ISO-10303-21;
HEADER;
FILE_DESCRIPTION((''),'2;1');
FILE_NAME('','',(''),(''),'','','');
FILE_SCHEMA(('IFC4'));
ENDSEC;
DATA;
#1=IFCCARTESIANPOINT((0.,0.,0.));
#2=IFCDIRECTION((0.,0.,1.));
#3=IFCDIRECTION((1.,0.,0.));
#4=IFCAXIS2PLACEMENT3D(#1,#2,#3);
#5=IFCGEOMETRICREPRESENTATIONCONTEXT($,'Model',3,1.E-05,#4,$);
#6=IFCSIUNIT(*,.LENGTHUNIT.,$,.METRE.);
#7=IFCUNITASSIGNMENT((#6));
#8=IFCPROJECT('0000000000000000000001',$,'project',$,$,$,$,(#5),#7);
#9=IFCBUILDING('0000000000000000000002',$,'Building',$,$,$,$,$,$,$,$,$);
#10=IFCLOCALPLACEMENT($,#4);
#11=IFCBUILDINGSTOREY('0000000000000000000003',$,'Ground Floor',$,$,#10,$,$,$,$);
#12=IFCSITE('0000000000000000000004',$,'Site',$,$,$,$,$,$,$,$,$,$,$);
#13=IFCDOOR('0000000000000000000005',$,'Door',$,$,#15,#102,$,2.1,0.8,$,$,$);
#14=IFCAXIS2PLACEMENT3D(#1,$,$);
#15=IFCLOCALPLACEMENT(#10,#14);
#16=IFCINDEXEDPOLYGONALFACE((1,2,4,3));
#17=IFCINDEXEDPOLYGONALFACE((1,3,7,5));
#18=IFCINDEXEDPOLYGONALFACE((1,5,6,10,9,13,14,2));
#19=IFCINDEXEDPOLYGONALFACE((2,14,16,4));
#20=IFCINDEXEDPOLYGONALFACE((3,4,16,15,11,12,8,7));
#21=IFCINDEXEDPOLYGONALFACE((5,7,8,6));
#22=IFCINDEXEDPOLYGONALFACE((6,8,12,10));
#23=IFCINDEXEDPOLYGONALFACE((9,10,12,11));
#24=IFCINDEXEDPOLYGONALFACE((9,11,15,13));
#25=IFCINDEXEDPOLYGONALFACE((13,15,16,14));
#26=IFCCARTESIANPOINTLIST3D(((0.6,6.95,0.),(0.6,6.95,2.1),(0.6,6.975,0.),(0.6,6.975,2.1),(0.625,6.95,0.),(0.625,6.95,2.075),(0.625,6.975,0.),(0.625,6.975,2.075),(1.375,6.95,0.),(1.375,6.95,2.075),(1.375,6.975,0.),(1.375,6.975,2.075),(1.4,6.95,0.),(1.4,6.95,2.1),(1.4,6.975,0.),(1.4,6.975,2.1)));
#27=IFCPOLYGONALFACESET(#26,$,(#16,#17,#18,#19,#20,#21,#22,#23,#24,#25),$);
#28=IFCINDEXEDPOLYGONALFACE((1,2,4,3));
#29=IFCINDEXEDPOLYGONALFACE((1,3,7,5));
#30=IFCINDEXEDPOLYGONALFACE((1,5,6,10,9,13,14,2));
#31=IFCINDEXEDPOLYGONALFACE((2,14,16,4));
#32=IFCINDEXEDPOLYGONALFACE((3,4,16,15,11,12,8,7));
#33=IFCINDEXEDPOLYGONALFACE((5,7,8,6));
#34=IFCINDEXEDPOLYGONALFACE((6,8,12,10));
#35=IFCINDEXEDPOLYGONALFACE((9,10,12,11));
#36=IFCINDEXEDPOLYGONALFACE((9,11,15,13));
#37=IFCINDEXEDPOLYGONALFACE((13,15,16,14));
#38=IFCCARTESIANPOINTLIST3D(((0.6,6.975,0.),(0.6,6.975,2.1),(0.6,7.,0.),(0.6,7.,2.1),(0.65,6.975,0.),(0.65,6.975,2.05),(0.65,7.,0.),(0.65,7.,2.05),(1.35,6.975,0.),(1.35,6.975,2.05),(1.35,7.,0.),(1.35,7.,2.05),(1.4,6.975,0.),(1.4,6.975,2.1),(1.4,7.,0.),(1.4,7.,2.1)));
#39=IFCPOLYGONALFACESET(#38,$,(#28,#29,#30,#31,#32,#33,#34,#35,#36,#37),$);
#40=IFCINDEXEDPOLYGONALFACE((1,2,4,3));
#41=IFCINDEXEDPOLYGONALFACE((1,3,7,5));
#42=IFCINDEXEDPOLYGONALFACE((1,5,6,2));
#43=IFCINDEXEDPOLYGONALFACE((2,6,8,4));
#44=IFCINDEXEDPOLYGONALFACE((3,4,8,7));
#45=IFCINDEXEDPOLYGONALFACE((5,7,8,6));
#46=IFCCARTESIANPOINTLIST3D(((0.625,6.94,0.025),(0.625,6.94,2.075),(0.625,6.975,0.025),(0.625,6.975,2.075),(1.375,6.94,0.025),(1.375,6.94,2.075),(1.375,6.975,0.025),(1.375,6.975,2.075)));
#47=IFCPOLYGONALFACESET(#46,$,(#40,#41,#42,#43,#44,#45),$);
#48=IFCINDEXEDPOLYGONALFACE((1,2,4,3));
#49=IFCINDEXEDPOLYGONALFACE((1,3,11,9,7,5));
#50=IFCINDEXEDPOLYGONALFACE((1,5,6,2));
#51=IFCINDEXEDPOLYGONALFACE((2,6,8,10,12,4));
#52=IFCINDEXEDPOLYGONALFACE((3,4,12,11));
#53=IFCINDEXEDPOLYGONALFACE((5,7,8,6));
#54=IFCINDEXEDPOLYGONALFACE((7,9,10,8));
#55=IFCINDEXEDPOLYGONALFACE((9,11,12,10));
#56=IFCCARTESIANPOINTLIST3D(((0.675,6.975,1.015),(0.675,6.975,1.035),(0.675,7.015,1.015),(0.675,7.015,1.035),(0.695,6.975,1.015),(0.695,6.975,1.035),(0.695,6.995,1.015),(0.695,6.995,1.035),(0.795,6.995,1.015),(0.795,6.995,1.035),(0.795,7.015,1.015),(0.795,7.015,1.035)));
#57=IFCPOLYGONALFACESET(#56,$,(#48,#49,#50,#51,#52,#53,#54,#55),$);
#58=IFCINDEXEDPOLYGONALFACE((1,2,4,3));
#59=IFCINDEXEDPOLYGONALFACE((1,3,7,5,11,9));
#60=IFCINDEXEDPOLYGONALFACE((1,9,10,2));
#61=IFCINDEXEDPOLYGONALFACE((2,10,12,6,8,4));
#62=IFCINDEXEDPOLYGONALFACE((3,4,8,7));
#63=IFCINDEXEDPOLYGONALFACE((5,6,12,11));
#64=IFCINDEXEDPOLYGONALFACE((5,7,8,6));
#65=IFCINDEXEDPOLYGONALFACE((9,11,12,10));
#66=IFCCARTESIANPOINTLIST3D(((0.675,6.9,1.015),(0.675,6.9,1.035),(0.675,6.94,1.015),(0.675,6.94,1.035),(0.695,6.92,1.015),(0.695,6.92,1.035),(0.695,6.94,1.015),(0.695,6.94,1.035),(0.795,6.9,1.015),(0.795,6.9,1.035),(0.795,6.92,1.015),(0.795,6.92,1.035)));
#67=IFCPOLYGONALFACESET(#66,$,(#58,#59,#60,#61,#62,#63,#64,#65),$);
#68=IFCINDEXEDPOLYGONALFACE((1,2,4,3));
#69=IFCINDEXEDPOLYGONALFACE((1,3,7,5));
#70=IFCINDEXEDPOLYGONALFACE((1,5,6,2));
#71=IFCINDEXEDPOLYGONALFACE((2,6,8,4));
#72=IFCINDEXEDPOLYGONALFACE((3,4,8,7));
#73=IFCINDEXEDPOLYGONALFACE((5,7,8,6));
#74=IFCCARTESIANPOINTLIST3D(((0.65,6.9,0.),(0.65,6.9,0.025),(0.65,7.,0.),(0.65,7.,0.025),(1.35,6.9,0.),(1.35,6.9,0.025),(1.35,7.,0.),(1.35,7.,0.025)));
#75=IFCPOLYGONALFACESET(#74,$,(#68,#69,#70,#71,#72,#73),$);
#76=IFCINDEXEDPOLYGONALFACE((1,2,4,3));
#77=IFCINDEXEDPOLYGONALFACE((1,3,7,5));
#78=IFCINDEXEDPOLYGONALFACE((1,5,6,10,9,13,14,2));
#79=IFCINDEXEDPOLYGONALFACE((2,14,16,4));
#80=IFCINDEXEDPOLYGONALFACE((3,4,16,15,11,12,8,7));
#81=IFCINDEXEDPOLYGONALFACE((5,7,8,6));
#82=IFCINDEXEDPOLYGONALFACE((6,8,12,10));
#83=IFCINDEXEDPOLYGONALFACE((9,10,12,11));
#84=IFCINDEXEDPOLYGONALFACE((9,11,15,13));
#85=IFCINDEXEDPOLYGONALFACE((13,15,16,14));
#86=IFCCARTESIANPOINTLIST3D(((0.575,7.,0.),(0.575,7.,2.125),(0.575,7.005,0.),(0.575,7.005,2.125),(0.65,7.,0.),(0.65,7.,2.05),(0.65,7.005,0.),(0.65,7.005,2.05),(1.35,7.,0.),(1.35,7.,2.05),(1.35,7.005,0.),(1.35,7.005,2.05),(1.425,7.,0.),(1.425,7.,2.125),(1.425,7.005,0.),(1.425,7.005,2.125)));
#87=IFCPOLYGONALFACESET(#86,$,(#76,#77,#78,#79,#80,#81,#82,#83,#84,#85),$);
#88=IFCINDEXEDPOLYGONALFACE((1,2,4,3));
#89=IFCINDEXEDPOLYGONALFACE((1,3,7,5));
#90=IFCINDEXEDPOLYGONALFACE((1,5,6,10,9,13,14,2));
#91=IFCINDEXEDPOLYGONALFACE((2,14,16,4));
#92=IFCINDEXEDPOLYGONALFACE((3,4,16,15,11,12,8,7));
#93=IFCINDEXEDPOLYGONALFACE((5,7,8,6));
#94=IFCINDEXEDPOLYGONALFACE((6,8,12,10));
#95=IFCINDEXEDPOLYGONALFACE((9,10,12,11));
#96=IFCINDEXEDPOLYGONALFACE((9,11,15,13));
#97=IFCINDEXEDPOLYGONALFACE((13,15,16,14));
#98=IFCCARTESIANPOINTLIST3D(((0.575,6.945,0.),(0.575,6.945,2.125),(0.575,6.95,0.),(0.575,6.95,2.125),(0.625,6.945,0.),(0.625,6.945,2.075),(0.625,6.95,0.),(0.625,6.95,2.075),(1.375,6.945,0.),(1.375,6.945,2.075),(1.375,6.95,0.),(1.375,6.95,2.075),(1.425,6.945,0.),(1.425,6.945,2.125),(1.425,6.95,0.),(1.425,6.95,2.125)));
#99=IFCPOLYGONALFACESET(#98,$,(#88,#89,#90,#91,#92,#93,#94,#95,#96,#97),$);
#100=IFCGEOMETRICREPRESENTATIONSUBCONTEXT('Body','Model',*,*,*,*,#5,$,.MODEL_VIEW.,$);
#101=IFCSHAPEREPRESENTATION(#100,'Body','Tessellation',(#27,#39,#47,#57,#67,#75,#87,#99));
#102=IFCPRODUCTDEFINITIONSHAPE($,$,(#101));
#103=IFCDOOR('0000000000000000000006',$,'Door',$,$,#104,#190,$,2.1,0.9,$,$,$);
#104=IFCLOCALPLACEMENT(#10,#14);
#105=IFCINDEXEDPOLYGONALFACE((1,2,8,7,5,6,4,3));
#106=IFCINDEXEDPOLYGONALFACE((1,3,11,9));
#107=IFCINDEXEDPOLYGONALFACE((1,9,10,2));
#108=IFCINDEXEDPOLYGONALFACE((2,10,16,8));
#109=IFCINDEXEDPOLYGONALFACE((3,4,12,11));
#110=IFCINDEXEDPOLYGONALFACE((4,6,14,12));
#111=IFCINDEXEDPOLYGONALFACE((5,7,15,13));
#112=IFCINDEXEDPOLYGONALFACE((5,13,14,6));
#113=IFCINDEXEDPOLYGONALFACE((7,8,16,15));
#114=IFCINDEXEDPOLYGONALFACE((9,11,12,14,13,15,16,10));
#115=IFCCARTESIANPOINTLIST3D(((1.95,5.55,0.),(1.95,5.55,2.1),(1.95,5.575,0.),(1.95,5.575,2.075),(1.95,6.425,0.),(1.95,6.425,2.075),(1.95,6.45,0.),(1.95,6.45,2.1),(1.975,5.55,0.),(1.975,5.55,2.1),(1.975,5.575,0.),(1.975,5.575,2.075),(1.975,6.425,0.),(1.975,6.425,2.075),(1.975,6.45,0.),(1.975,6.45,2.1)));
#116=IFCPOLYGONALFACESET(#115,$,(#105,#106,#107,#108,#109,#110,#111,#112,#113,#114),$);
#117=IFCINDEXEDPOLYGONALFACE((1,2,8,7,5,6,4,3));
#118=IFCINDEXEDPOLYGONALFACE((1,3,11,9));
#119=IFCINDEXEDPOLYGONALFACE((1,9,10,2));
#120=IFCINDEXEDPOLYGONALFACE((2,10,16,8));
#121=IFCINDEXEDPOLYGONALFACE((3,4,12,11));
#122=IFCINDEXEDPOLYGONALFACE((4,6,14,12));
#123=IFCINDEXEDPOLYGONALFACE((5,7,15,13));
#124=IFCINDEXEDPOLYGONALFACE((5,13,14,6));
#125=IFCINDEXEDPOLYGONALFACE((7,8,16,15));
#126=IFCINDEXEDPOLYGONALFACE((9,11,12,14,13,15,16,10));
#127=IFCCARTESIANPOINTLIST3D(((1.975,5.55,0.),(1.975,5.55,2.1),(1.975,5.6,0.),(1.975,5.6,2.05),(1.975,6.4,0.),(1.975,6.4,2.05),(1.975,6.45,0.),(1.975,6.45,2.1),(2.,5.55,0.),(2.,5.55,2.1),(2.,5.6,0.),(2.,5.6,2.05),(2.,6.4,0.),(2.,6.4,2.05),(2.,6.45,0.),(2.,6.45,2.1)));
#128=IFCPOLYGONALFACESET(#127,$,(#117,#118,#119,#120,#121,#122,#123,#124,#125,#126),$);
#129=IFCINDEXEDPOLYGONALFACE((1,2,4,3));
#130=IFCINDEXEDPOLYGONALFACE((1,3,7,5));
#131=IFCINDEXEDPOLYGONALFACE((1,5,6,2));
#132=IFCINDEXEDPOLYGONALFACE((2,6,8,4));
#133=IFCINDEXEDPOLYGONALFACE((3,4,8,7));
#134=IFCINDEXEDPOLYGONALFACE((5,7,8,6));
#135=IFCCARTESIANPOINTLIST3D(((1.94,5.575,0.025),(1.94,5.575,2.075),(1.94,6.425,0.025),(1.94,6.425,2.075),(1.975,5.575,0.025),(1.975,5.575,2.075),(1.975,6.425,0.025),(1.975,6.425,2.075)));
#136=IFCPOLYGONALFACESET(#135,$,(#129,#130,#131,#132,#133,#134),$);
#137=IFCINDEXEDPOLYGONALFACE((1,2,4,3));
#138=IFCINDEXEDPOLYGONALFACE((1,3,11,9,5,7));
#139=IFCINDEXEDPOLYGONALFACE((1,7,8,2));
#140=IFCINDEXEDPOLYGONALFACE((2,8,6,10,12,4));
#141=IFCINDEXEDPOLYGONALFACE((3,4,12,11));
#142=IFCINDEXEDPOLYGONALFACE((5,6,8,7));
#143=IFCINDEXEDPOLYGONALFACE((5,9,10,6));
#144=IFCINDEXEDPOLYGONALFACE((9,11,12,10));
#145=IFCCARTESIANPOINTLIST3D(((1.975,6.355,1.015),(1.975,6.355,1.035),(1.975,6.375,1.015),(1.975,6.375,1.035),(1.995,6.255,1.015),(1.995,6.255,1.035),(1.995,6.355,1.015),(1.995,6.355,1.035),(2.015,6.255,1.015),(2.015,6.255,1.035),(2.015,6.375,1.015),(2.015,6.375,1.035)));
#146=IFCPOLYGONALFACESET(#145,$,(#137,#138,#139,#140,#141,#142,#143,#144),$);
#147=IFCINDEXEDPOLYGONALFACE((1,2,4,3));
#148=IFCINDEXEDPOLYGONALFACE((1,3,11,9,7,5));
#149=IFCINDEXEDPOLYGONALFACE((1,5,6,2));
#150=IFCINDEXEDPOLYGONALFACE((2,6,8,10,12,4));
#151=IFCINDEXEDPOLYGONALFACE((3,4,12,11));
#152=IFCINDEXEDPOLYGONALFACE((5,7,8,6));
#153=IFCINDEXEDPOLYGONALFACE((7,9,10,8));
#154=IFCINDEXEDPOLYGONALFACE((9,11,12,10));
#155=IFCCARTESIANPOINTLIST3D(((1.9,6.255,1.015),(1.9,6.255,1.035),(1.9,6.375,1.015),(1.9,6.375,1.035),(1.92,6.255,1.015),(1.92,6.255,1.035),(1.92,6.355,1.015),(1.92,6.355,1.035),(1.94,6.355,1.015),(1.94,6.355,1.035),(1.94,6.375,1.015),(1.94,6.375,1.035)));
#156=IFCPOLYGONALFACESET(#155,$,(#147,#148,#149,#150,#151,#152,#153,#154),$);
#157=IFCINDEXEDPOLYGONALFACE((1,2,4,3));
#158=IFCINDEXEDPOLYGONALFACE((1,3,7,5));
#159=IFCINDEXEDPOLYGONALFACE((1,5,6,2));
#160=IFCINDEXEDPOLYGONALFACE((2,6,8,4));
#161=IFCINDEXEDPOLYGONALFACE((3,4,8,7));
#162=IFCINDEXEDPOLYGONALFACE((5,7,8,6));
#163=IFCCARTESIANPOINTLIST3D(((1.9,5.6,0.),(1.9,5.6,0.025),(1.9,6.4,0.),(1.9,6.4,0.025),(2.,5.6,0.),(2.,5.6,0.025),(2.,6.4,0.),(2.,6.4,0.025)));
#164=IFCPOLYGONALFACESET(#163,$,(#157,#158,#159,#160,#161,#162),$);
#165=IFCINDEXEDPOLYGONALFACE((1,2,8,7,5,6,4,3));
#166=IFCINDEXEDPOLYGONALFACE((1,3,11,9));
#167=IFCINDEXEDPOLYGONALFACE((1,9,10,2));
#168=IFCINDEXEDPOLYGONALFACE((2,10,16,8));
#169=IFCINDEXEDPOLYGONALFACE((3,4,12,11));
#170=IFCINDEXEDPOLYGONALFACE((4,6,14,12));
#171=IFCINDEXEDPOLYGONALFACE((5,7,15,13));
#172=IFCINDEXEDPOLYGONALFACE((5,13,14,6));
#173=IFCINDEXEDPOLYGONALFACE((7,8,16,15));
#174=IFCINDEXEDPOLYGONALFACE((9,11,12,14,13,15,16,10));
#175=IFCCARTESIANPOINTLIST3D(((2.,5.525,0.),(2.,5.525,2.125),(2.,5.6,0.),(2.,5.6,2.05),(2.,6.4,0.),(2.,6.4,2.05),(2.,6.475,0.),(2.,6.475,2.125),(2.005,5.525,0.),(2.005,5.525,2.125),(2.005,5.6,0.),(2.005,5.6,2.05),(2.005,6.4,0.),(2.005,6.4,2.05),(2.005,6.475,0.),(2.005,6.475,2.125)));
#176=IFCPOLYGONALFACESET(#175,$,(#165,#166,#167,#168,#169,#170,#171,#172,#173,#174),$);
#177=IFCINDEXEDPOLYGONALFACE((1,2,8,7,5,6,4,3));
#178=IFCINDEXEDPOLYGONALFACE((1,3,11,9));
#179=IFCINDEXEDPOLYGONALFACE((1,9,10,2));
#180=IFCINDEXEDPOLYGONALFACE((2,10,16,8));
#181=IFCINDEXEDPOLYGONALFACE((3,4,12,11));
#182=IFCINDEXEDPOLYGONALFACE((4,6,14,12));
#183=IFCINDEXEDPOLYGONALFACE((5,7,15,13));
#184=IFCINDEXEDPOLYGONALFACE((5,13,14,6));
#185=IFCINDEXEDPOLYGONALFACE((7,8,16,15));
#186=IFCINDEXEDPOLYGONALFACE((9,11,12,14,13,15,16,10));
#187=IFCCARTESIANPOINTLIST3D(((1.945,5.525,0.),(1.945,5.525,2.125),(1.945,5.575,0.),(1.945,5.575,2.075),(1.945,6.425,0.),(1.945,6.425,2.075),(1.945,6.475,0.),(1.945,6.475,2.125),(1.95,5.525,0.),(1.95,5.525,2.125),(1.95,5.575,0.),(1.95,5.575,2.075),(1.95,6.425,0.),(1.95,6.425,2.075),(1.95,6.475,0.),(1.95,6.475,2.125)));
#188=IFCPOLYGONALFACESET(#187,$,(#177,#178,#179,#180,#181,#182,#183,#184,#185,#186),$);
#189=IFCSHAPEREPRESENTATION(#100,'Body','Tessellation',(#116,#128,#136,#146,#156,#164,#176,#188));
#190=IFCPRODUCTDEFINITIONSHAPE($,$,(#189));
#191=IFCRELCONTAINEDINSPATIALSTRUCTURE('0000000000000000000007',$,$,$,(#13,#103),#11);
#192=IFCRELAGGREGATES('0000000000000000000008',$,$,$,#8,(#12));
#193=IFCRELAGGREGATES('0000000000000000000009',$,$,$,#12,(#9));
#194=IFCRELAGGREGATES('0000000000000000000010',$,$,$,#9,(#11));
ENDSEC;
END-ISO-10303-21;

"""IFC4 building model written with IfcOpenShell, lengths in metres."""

from ifc_helpers import new_model, si_unit, frame, origin_with_axes, place, context, subcontext, project, spatial, line, indexed_curve, outline, extrude, element, save


model = new_model("IFC4")

# Units and contexts
model_context = context("Model", 3, precision=1e-05, world=origin_with_axes())
body_context = subcontext(model_context, "Body", "Model", "MODEL_VIEW")
ifc_project = project(units=[si_unit("LENGTHUNIT", "METRE")], contexts=[model_context])

# Site, building, storey
site = spatial("IfcSite", under=ifc_project, Name="Site")
building = spatial("IfcBuilding", under=site, Name="Building")
storey_placement = place(None, origin_with_axes())
storey = spatial("IfcBuildingStorey", under=building, at=storey_placement, Name="Ground Floor")

# Doors
door_1_placement = place(storey_placement, frame((1.4, 7.0, 0.0), z_axis=(0.0, 0.0, 1.0), x_axis=(-1.0, 0.0, 0.0)))
element("IfcDoor", 1, at=door_1_placement, inside=storey, Name="Door", OverallHeight=2.1, OverallWidth=0.8, context=body_context, shape_type="SweptSolid", body=[
    extrude(outline(indexed_curve([(0.0, 0.0), (0.0, 2.1), (0.8, 2.1), (0.8, 0.0), (0.775, 0.0), (0.775, 2.075), (0.025, 2.075), (0.025, 0.0)], segments=[line(1, 2, 3, 4, 5, 6, 7, 8, 1)])), frame((0.0, 0.025, 0.0), z_axis=(0.0, -1.0, 0.0), x_axis=(1.0, 0.0, 0.0)), (0.0, 0.0, -1.0), 0.025),
    extrude(outline(indexed_curve([(0.0, 0.0), (0.0, 2.1), (0.8, 2.1), (0.8, 0.0), (0.75, 0.0), (0.75, 2.05), (0.05, 2.05), (0.05, 0.0)], segments=[line(1, 2, 3, 4, 5, 6, 7, 8, 1)])), frame((0.0, 0.0, 0.0), z_axis=(0.0, -1.0, 0.0), x_axis=(1.0, 0.0, 0.0)), (0.0, 0.0, -1.0), 0.025),
    extrude(outline(indexed_curve([(0.0, 0.0), (0.75, 0.0), (0.75, 0.035), (0.0, 0.035)], segments=[line(1, 2, 3, 4, 1)])), frame((0.025, 0.025, 0.025), z_axis=(0.0, 0.0, 1.0), x_axis=(1.0, 0.0, 0.0)), (0.0, 0.0, 1.0), 2.05),
    extrude(outline(indexed_curve([(0.0, 0.0), (0.0, -0.04), (-0.12, -0.04), (-0.12, -0.02), (-0.02, -0.02), (-0.02, 0.0)], segments=[line(1, 2, 3, 4, 5, 6, 1)])), frame((0.725, 0.025, 1.015), z_axis=(0.0, 0.0, 1.0), x_axis=(1.0, 0.0, 0.0)), (0.0, 0.0, 1.0), 0.02),
    extrude(outline(indexed_curve([(0.0, 0.0), (0.0, 0.04), (-0.12, 0.04), (-0.12, 0.02), (-0.02, 0.02), (-0.02, 0.0)], segments=[line(1, 2, 3, 4, 5, 6, 1)])), frame((0.725, 0.06, 1.015), z_axis=(0.0, 0.0, 1.0), x_axis=(1.0, 0.0, 0.0)), (0.0, 0.0, 1.0), 0.02),
    extrude(outline(indexed_curve([(0.0, 0.0), (0.7, 0.0), (0.7, 0.1), (0.0, 0.1)], segments=[line(1, 2, 3, 4, 1)])), frame((0.05, 0.0, 0.0), z_axis=(0.0, 0.0, 1.0), x_axis=(1.0, 0.0, 0.0)), (0.0, 0.0, 1.0), 0.025),
    extrude(outline(indexed_curve([(0.0, 0.0), (0.0, 2.125), (0.85, 2.125), (0.85, 0.0), (0.775, 0.0), (0.775, 2.05), (0.075, 2.05), (0.075, 0.0)], segments=[line(1, 2, 3, 4, 5, 6, 7, 8, 1)])), frame((-0.025, -0.005, 0.0), z_axis=(0.0, -1.0, 0.0), x_axis=(1.0, 0.0, 0.0)), (0.0, 0.0, -1.0), 0.005),
    extrude(outline(indexed_curve([(0.0, 0.0), (0.0, 2.125), (0.85, 2.125), (0.85, 0.0), (0.8, 0.0), (0.8, 2.075), (0.05, 2.075), (0.05, 0.0)], segments=[line(1, 2, 3, 4, 5, 6, 7, 8, 1)])), frame((-0.025, 0.05, 0.0), z_axis=(0.0, -1.0, 0.0), x_axis=(1.0, 0.0, 0.0)), (0.0, 0.0, -1.0), 0.005),
])
door_2_placement = place(storey_placement, frame((2.0, 5.55, 0.0), z_axis=(0.0, 0.0, 1.0), x_axis=(0.0, 1.0, 0.0)))
element("IfcDoor", 2, at=door_2_placement, inside=storey, Name="Door", OverallHeight=2.1, OverallWidth=0.9, context=body_context, shape_type="SweptSolid", body=[
    extrude(outline(indexed_curve([(0.0, 0.0), (0.0, 2.1), (0.9, 2.1), (0.9, 0.0), (0.875, 0.0), (0.875, 2.075), (0.025, 2.075), (0.025, 0.0)], segments=[line(1, 2, 3, 4, 5, 6, 7, 8, 1)])), frame((0.0, 0.025, 0.0), z_axis=(0.0, -1.0, 0.0), x_axis=(1.0, 0.0, 0.0)), (0.0, 0.0, -1.0), 0.025),
    extrude(outline(indexed_curve([(0.0, 0.0), (0.0, 2.1), (0.9, 2.1), (0.9, 0.0), (0.85, 0.0), (0.85, 2.05), (0.05, 2.05), (0.05, 0.0)], segments=[line(1, 2, 3, 4, 5, 6, 7, 8, 1)])), frame((0.0, 0.0, 0.0), z_axis=(0.0, -1.0, 0.0), x_axis=(1.0, 0.0, 0.0)), (0.0, 0.0, -1.0), 0.025),
    extrude(outline(indexed_curve([(0.0, 0.0), (0.85, 0.0), (0.85, 0.035), (0.0, 0.035)], segments=[line(1, 2, 3, 4, 1)])), frame((0.025, 0.025, 0.025), z_axis=(0.0, 0.0, 1.0), x_axis=(1.0, 0.0, 0.0)), (0.0, 0.0, 1.0), 2.05),
    extrude(outline(indexed_curve([(0.0, 0.0), (0.0, -0.04), (-0.12, -0.04), (-0.12, -0.02), (-0.02, -0.02), (-0.02, 0.0)], segments=[line(1, 2, 3, 4, 5, 6, 1)])), frame((0.825, 0.025, 1.015), z_axis=(0.0, 0.0, 1.0), x_axis=(1.0, 0.0, 0.0)), (0.0, 0.0, 1.0), 0.02),
    extrude(outline(indexed_curve([(0.0, 0.0), (0.0, 0.04), (-0.12, 0.04), (-0.12, 0.02), (-0.02, 0.02), (-0.02, 0.0)], segments=[line(1, 2, 3, 4, 5, 6, 1)])), frame((0.825, 0.06, 1.015), z_axis=(0.0, 0.0, 1.0), x_axis=(1.0, 0.0, 0.0)), (0.0, 0.0, 1.0), 0.02),
    extrude(outline(indexed_curve([(0.0, 0.0), (0.8, 0.0), (0.8, 0.1), (0.0, 0.1)], segments=[line(1, 2, 3, 4, 1)])), frame((0.05, 0.0, 0.0), z_axis=(0.0, 0.0, 1.0), x_axis=(1.0, 0.0, 0.0)), (0.0, 0.0, 1.0), 0.025),
    extrude(outline(indexed_curve([(0.0, 0.0), (0.0, 2.125), (0.95, 2.125), (0.95, 0.0), (0.875, 0.0), (0.875, 2.05), (0.075, 2.05), (0.075, 0.0)], segments=[line(1, 2, 3, 4, 5, 6, 7, 8, 1)])), frame((-0.025, -0.005, 0.0), z_axis=(0.0, -1.0, 0.0), x_axis=(1.0, 0.0, 0.0)), (0.0, 0.0, -1.0), 0.005),
    extrude(outline(indexed_curve([(0.0, 0.0), (0.0, 2.125), (0.95, 2.125), (0.95, 0.0), (0.9, 0.0), (0.9, 2.075), (0.05, 2.075), (0.05, 0.0)], segments=[line(1, 2, 3, 4, 5, 6, 7, 8, 1)])), frame((-0.025, 0.05, 0.0), z_axis=(0.0, -1.0, 0.0), x_axis=(1.0, 0.0, 0.0)), (0.0, 0.0, -1.0), 0.005),
])

save(model, "model.ifc")
